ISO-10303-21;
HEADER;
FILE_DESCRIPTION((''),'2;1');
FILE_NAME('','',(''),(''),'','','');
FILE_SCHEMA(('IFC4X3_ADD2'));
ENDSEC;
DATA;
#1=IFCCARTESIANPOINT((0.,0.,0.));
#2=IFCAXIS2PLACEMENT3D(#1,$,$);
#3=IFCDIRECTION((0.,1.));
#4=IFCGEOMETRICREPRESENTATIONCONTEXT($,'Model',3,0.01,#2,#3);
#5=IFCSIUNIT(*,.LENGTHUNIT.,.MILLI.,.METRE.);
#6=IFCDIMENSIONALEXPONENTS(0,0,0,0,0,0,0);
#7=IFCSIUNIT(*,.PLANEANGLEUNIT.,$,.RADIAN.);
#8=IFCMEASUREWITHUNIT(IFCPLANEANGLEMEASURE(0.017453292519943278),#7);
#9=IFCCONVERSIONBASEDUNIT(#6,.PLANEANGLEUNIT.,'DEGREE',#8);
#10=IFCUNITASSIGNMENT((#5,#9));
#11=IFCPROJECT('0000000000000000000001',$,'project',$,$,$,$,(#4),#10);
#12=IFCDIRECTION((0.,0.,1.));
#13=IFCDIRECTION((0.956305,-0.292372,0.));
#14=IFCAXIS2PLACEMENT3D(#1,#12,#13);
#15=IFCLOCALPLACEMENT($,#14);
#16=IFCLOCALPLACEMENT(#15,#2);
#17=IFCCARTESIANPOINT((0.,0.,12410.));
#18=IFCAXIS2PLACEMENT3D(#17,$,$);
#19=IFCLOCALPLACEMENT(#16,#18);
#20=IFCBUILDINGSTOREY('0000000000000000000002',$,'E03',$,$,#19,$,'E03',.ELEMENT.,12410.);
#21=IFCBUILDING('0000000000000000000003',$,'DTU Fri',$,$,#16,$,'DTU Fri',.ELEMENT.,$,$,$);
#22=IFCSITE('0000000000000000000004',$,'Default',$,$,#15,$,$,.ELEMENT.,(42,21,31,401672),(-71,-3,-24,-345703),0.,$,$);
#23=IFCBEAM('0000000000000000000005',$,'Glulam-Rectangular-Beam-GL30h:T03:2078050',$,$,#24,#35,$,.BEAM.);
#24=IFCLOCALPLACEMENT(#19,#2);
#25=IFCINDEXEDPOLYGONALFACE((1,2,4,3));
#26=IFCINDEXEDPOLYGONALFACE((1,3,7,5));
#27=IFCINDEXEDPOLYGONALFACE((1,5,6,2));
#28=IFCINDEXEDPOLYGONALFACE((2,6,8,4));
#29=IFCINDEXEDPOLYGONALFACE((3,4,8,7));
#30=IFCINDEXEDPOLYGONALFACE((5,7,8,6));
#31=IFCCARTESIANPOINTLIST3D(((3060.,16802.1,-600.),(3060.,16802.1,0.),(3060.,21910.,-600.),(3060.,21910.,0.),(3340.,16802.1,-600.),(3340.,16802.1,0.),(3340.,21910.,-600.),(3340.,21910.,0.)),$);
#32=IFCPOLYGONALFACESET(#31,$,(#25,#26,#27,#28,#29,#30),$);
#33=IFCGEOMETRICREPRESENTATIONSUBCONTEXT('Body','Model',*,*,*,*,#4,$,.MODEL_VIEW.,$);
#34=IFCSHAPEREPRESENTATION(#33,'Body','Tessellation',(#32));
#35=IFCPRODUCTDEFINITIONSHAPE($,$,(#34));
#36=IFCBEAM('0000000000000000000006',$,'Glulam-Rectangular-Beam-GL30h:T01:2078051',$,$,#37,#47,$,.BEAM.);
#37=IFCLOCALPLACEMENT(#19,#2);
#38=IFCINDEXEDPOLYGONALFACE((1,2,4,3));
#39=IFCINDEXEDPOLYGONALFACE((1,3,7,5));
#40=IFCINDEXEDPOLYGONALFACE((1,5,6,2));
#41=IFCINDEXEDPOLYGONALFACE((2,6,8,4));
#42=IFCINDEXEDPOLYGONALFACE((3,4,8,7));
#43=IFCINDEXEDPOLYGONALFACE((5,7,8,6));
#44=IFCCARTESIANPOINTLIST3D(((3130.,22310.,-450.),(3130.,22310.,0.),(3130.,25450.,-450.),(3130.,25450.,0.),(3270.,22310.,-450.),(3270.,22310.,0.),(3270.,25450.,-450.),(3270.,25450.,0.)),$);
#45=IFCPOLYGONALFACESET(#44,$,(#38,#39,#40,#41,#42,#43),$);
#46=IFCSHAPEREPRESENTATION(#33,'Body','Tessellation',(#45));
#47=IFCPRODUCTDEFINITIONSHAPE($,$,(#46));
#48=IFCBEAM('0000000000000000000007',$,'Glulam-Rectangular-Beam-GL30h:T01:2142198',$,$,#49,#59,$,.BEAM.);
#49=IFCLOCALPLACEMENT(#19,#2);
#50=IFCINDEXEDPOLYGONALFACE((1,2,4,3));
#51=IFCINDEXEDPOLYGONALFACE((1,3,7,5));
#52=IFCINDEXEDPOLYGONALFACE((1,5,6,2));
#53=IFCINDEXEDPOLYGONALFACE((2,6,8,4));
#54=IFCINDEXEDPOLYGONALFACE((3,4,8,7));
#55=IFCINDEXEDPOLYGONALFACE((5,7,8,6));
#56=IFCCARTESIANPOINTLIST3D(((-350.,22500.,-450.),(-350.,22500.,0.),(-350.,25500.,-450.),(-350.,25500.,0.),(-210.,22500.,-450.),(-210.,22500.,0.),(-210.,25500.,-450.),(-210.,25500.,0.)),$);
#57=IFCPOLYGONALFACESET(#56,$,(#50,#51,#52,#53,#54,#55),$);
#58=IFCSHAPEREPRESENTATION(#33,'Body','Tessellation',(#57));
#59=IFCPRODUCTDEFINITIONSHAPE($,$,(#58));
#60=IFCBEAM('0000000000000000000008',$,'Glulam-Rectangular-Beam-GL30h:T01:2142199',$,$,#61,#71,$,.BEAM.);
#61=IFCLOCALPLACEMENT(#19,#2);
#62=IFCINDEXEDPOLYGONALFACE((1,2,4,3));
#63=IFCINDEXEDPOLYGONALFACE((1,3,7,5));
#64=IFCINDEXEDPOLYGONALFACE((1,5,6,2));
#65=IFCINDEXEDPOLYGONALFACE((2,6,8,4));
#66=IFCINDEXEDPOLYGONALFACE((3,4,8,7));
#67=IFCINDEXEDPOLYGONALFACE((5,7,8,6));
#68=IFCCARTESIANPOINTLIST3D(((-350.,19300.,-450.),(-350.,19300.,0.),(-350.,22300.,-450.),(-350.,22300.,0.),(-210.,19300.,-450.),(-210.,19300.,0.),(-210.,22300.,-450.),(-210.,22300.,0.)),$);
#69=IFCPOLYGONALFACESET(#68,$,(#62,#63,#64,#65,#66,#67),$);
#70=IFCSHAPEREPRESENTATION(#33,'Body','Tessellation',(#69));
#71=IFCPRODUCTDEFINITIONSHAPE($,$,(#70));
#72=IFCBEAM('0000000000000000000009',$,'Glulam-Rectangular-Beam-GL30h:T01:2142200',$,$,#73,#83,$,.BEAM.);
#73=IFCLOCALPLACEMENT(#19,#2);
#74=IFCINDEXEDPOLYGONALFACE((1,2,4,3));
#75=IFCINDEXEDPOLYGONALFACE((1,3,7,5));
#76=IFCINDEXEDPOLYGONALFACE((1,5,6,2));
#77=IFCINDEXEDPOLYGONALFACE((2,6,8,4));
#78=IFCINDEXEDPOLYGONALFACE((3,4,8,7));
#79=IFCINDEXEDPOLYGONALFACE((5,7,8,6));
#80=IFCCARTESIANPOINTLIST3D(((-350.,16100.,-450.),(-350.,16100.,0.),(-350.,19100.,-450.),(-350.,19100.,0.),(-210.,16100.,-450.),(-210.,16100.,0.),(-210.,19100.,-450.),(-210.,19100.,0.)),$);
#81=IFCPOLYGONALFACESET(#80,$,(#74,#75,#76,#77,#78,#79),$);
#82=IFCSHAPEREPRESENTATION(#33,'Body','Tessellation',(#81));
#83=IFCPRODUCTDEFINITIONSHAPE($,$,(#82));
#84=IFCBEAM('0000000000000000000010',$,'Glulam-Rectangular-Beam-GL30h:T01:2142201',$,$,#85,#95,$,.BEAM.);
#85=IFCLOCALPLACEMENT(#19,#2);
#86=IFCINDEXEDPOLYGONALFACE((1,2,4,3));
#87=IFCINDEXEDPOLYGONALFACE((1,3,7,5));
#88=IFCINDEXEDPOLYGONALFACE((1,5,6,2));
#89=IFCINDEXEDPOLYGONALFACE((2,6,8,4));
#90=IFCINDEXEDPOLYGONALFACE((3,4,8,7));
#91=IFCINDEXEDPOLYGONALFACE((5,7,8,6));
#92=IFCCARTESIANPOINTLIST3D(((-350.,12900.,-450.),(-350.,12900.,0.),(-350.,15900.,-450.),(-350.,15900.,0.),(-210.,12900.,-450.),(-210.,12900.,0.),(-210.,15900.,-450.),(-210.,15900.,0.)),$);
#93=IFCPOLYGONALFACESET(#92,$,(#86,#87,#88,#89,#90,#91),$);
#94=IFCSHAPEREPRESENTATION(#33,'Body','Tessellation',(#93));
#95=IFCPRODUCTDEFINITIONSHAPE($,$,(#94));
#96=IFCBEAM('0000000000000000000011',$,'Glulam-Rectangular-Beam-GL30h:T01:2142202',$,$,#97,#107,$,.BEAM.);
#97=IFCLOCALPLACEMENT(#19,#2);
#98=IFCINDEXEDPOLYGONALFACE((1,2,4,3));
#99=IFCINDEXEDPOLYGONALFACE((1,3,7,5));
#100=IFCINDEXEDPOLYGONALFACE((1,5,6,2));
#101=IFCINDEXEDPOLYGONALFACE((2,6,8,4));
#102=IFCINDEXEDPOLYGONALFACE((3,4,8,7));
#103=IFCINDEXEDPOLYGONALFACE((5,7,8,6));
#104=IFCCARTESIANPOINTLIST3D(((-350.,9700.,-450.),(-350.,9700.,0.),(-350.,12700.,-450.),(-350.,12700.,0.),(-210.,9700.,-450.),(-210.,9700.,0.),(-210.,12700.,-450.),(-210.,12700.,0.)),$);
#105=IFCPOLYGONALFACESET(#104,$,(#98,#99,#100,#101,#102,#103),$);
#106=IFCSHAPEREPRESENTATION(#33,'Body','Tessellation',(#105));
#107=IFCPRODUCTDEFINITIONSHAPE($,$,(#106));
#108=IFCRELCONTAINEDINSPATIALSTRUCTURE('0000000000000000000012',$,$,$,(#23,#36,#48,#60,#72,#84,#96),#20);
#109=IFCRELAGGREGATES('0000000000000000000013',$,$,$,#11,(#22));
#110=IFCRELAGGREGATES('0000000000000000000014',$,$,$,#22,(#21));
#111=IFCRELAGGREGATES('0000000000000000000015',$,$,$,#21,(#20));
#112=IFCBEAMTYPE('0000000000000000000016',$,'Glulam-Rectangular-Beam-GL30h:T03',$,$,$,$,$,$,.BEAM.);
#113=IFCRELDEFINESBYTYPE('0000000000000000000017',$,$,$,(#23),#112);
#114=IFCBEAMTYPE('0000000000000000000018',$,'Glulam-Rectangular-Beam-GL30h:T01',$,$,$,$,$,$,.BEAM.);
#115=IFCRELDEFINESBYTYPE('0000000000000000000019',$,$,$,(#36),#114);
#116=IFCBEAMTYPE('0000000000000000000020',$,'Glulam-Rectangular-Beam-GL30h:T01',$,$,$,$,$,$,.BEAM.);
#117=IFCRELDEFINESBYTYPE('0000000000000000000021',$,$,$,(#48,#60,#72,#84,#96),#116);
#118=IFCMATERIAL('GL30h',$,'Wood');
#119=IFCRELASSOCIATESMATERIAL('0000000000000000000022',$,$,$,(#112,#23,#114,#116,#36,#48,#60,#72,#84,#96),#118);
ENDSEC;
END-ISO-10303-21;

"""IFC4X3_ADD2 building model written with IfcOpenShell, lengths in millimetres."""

from ifc_helpers import new_model, entity, si_unit, converted_unit, direction, frame, origin, origin_2d_with_axis, place, context, subcontext, project, spatial, rectangle, extrude, source, transform, mapped, material, material_profile, profile_set, profile_usage, type_object, type_shapes, element, save


model = new_model("IFC4X3_ADD2")

# Units and contexts
model_context = context("Model", 3, precision=0.01, world=origin(), true_north=direction((0.0, 1.0)))
body_context = subcontext(model_context, "Body", "Model", "MODEL_VIEW")
ifc_project = project(units=[si_unit("LENGTHUNIT", "METRE", prefix="MILLI"), converted_unit("PLANEANGLEUNIT", "DEGREE", entity("IfcPlaneAngleMeasure", 0.017453292519943278), si_unit("PLANEANGLEUNIT", "RADIAN"), dimensions=[0, 0, 0, 0, 0, 0, 0])], contexts=[model_context])

# Site, building, storey
site_placement = place(None, frame((0.0, 0.0, 0.0), z_axis=(0.0, 0.0, 1.0), x_axis=(0.956305, -0.292372, 0.0)))
site = spatial("IfcSite", under=ifc_project, at=site_placement, Name="Default", CompositionType="ELEMENT", RefLatitude=(42, 21, 31, 401672), RefLongitude=(-71, -3, -24, -345703), RefElevation=0.0)
building_placement = place(site_placement, origin())
building = spatial("IfcBuilding", under=site, at=building_placement, Name="DTU Fri", LongName="DTU Fri", CompositionType="ELEMENT")
storey_placement = place(building_placement, frame((0.0, 0.0, 12410.0)))
storey = spatial("IfcBuildingStorey", under=building, at=storey_placement, Name="E03", LongName="E03", CompositionType="ELEMENT", Elevation=12410.0)

# Shared definitions
ifc_material = material(Name="GL30h", Category="Wood")

# Beams
ifc_material_profile_1 = material_profile(ifc_material, rectangle(XDim=600.0, YDim=280.0, at=origin_2d_with_axis()), Name="T03")
ifc_profile_set_1 = profile_set([ifc_material_profile_1], Name="T03")
ifc_profile_usage_1 = profile_usage(ifc_profile_set_1, cardinal=8)
beam_type_1 = type_object("IfcBeamType", Name="Glulam-Rectangular-Beam-GL30h:T03", PredefinedType="BEAM", material=ifc_profile_set_1)
shared_shape_1 = source(origin(), body_context, "Body", "SweptSolid", [
    extrude(rectangle(XDim=600.0, YDim=280.0, at=origin_2d_with_axis()), frame((-2554.0, 0.0, 0.0), z_axis=(1.0, 0.0, 0.0), x_axis=(0.0, 0.0, -1.0)), (0.0, 0.0, 1.0), 5107.9),
])
type_shapes(beam_type_1, [shared_shape_1])
beam_1_placement = place(storey_placement, frame((3200.0, 19356.0, -300.0), z_axis=(0.0, 0.0, 1.0), x_axis=(0.0, 1.0, 0.0)))
element("IfcBeam", 1, at=beam_1_placement, inside=storey, type_object=beam_type_1, material=ifc_profile_usage_1, Name="Glulam-Rectangular-Beam-GL30h:T03:2078050", PredefinedType="BEAM", context=body_context, shape_type="MappedRepresentation", body=[
    mapped(shared_shape_1, transform((0.0, 0.0, 0.0), scale=1.0)),
])
ifc_material_profile_2 = material_profile(ifc_material, rectangle(XDim=450.0, YDim=140.0, at=origin_2d_with_axis()), Name="T01")
ifc_profile_set_2 = profile_set([ifc_material_profile_2], Name="T01")
ifc_profile_usage_2 = profile_usage(ifc_profile_set_2, cardinal=8)
beam_type_2 = type_object("IfcBeamType", Name="Glulam-Rectangular-Beam-GL30h:T01", PredefinedType="BEAM", material=ifc_profile_set_2)
shared_shape_2 = source(origin(), body_context, "Body", "SweptSolid", [
    extrude(rectangle(XDim=450.0, YDim=140.0, at=origin_2d_with_axis()), frame((-1545.0, 0.0, 0.0), z_axis=(1.0, 0.0, 0.0), x_axis=(0.0, 0.0, -1.0)), (0.0, 0.0, 1.0), 3140.0),
])
type_shapes(beam_type_2, [shared_shape_2])
beam_2_placement = place(storey_placement, frame((3200.0, 23855.0, -225.0), z_axis=(0.0, 0.0, 1.0), x_axis=(0.0, 1.0, 0.0)))
element("IfcBeam", 2, at=beam_2_placement, inside=storey, type_object=beam_type_2, material=ifc_profile_usage_2, Name="Glulam-Rectangular-Beam-GL30h:T01:2078051", PredefinedType="BEAM", context=body_context, shape_type="MappedRepresentation", body=[
    mapped(shared_shape_2, transform((0.0, 0.0, 0.0), scale=1.0)),
])
beam_type_3 = type_object("IfcBeamType", Name="Glulam-Rectangular-Beam-GL30h:T01", PredefinedType="BEAM", material=ifc_profile_set_2)
shared_shape_3 = source(origin(), body_context, "Body", "SweptSolid", [
    extrude(rectangle(XDim=450.0, YDim=140.0, at=origin_2d_with_axis()), frame((-1500.0, 0.0, 0.0), z_axis=(1.0, 0.0, 0.0), x_axis=(0.0, 0.0, -1.0)), (0.0, 0.0, 1.0), 3000.0),
])
type_shapes(beam_type_3, [shared_shape_3])
for number, where, z_axis, x_axis, name in (
    (3, (-280.0, 24000.0, -225.0), (0.0, 0.0, 1.0), (0.0, 1.0, 0.0), "Glulam-Rectangular-Beam-GL30h:T01:2142198"),
    (4, (-280.0, 20800.0, -225.0), (0.0, 0.0, 1.0), (0.0, 1.0, 0.0), "Glulam-Rectangular-Beam-GL30h:T01:2142199"),
    (5, (-280.0, 17600.0, -225.0), (0.0, 0.0, 1.0), (0.0, 1.0, 0.0), "Glulam-Rectangular-Beam-GL30h:T01:2142200"),
    (6, (-280.0, 14400.0, -225.0), (0.0, 0.0, 1.0), (0.0, 1.0, 0.0), "Glulam-Rectangular-Beam-GL30h:T01:2142201"),
    (7, (-280.0, 11200.0, -225.0), (0.0, 0.0, 1.0), (0.0, 1.0, 0.0), "Glulam-Rectangular-Beam-GL30h:T01:2142202"),
):
    element("IfcBeam", number, at=place(storey_placement, frame(where, z_axis=z_axis, x_axis=x_axis)), inside=storey, type_object=beam_type_3, material=ifc_profile_usage_2, Name=name, PredefinedType="BEAM", context=body_context, shape_type="MappedRepresentation", body=[
        mapped(shared_shape_3, transform((0.0, 0.0, 0.0), scale=1.0)),
    ])

save(model, "model.ifc")
